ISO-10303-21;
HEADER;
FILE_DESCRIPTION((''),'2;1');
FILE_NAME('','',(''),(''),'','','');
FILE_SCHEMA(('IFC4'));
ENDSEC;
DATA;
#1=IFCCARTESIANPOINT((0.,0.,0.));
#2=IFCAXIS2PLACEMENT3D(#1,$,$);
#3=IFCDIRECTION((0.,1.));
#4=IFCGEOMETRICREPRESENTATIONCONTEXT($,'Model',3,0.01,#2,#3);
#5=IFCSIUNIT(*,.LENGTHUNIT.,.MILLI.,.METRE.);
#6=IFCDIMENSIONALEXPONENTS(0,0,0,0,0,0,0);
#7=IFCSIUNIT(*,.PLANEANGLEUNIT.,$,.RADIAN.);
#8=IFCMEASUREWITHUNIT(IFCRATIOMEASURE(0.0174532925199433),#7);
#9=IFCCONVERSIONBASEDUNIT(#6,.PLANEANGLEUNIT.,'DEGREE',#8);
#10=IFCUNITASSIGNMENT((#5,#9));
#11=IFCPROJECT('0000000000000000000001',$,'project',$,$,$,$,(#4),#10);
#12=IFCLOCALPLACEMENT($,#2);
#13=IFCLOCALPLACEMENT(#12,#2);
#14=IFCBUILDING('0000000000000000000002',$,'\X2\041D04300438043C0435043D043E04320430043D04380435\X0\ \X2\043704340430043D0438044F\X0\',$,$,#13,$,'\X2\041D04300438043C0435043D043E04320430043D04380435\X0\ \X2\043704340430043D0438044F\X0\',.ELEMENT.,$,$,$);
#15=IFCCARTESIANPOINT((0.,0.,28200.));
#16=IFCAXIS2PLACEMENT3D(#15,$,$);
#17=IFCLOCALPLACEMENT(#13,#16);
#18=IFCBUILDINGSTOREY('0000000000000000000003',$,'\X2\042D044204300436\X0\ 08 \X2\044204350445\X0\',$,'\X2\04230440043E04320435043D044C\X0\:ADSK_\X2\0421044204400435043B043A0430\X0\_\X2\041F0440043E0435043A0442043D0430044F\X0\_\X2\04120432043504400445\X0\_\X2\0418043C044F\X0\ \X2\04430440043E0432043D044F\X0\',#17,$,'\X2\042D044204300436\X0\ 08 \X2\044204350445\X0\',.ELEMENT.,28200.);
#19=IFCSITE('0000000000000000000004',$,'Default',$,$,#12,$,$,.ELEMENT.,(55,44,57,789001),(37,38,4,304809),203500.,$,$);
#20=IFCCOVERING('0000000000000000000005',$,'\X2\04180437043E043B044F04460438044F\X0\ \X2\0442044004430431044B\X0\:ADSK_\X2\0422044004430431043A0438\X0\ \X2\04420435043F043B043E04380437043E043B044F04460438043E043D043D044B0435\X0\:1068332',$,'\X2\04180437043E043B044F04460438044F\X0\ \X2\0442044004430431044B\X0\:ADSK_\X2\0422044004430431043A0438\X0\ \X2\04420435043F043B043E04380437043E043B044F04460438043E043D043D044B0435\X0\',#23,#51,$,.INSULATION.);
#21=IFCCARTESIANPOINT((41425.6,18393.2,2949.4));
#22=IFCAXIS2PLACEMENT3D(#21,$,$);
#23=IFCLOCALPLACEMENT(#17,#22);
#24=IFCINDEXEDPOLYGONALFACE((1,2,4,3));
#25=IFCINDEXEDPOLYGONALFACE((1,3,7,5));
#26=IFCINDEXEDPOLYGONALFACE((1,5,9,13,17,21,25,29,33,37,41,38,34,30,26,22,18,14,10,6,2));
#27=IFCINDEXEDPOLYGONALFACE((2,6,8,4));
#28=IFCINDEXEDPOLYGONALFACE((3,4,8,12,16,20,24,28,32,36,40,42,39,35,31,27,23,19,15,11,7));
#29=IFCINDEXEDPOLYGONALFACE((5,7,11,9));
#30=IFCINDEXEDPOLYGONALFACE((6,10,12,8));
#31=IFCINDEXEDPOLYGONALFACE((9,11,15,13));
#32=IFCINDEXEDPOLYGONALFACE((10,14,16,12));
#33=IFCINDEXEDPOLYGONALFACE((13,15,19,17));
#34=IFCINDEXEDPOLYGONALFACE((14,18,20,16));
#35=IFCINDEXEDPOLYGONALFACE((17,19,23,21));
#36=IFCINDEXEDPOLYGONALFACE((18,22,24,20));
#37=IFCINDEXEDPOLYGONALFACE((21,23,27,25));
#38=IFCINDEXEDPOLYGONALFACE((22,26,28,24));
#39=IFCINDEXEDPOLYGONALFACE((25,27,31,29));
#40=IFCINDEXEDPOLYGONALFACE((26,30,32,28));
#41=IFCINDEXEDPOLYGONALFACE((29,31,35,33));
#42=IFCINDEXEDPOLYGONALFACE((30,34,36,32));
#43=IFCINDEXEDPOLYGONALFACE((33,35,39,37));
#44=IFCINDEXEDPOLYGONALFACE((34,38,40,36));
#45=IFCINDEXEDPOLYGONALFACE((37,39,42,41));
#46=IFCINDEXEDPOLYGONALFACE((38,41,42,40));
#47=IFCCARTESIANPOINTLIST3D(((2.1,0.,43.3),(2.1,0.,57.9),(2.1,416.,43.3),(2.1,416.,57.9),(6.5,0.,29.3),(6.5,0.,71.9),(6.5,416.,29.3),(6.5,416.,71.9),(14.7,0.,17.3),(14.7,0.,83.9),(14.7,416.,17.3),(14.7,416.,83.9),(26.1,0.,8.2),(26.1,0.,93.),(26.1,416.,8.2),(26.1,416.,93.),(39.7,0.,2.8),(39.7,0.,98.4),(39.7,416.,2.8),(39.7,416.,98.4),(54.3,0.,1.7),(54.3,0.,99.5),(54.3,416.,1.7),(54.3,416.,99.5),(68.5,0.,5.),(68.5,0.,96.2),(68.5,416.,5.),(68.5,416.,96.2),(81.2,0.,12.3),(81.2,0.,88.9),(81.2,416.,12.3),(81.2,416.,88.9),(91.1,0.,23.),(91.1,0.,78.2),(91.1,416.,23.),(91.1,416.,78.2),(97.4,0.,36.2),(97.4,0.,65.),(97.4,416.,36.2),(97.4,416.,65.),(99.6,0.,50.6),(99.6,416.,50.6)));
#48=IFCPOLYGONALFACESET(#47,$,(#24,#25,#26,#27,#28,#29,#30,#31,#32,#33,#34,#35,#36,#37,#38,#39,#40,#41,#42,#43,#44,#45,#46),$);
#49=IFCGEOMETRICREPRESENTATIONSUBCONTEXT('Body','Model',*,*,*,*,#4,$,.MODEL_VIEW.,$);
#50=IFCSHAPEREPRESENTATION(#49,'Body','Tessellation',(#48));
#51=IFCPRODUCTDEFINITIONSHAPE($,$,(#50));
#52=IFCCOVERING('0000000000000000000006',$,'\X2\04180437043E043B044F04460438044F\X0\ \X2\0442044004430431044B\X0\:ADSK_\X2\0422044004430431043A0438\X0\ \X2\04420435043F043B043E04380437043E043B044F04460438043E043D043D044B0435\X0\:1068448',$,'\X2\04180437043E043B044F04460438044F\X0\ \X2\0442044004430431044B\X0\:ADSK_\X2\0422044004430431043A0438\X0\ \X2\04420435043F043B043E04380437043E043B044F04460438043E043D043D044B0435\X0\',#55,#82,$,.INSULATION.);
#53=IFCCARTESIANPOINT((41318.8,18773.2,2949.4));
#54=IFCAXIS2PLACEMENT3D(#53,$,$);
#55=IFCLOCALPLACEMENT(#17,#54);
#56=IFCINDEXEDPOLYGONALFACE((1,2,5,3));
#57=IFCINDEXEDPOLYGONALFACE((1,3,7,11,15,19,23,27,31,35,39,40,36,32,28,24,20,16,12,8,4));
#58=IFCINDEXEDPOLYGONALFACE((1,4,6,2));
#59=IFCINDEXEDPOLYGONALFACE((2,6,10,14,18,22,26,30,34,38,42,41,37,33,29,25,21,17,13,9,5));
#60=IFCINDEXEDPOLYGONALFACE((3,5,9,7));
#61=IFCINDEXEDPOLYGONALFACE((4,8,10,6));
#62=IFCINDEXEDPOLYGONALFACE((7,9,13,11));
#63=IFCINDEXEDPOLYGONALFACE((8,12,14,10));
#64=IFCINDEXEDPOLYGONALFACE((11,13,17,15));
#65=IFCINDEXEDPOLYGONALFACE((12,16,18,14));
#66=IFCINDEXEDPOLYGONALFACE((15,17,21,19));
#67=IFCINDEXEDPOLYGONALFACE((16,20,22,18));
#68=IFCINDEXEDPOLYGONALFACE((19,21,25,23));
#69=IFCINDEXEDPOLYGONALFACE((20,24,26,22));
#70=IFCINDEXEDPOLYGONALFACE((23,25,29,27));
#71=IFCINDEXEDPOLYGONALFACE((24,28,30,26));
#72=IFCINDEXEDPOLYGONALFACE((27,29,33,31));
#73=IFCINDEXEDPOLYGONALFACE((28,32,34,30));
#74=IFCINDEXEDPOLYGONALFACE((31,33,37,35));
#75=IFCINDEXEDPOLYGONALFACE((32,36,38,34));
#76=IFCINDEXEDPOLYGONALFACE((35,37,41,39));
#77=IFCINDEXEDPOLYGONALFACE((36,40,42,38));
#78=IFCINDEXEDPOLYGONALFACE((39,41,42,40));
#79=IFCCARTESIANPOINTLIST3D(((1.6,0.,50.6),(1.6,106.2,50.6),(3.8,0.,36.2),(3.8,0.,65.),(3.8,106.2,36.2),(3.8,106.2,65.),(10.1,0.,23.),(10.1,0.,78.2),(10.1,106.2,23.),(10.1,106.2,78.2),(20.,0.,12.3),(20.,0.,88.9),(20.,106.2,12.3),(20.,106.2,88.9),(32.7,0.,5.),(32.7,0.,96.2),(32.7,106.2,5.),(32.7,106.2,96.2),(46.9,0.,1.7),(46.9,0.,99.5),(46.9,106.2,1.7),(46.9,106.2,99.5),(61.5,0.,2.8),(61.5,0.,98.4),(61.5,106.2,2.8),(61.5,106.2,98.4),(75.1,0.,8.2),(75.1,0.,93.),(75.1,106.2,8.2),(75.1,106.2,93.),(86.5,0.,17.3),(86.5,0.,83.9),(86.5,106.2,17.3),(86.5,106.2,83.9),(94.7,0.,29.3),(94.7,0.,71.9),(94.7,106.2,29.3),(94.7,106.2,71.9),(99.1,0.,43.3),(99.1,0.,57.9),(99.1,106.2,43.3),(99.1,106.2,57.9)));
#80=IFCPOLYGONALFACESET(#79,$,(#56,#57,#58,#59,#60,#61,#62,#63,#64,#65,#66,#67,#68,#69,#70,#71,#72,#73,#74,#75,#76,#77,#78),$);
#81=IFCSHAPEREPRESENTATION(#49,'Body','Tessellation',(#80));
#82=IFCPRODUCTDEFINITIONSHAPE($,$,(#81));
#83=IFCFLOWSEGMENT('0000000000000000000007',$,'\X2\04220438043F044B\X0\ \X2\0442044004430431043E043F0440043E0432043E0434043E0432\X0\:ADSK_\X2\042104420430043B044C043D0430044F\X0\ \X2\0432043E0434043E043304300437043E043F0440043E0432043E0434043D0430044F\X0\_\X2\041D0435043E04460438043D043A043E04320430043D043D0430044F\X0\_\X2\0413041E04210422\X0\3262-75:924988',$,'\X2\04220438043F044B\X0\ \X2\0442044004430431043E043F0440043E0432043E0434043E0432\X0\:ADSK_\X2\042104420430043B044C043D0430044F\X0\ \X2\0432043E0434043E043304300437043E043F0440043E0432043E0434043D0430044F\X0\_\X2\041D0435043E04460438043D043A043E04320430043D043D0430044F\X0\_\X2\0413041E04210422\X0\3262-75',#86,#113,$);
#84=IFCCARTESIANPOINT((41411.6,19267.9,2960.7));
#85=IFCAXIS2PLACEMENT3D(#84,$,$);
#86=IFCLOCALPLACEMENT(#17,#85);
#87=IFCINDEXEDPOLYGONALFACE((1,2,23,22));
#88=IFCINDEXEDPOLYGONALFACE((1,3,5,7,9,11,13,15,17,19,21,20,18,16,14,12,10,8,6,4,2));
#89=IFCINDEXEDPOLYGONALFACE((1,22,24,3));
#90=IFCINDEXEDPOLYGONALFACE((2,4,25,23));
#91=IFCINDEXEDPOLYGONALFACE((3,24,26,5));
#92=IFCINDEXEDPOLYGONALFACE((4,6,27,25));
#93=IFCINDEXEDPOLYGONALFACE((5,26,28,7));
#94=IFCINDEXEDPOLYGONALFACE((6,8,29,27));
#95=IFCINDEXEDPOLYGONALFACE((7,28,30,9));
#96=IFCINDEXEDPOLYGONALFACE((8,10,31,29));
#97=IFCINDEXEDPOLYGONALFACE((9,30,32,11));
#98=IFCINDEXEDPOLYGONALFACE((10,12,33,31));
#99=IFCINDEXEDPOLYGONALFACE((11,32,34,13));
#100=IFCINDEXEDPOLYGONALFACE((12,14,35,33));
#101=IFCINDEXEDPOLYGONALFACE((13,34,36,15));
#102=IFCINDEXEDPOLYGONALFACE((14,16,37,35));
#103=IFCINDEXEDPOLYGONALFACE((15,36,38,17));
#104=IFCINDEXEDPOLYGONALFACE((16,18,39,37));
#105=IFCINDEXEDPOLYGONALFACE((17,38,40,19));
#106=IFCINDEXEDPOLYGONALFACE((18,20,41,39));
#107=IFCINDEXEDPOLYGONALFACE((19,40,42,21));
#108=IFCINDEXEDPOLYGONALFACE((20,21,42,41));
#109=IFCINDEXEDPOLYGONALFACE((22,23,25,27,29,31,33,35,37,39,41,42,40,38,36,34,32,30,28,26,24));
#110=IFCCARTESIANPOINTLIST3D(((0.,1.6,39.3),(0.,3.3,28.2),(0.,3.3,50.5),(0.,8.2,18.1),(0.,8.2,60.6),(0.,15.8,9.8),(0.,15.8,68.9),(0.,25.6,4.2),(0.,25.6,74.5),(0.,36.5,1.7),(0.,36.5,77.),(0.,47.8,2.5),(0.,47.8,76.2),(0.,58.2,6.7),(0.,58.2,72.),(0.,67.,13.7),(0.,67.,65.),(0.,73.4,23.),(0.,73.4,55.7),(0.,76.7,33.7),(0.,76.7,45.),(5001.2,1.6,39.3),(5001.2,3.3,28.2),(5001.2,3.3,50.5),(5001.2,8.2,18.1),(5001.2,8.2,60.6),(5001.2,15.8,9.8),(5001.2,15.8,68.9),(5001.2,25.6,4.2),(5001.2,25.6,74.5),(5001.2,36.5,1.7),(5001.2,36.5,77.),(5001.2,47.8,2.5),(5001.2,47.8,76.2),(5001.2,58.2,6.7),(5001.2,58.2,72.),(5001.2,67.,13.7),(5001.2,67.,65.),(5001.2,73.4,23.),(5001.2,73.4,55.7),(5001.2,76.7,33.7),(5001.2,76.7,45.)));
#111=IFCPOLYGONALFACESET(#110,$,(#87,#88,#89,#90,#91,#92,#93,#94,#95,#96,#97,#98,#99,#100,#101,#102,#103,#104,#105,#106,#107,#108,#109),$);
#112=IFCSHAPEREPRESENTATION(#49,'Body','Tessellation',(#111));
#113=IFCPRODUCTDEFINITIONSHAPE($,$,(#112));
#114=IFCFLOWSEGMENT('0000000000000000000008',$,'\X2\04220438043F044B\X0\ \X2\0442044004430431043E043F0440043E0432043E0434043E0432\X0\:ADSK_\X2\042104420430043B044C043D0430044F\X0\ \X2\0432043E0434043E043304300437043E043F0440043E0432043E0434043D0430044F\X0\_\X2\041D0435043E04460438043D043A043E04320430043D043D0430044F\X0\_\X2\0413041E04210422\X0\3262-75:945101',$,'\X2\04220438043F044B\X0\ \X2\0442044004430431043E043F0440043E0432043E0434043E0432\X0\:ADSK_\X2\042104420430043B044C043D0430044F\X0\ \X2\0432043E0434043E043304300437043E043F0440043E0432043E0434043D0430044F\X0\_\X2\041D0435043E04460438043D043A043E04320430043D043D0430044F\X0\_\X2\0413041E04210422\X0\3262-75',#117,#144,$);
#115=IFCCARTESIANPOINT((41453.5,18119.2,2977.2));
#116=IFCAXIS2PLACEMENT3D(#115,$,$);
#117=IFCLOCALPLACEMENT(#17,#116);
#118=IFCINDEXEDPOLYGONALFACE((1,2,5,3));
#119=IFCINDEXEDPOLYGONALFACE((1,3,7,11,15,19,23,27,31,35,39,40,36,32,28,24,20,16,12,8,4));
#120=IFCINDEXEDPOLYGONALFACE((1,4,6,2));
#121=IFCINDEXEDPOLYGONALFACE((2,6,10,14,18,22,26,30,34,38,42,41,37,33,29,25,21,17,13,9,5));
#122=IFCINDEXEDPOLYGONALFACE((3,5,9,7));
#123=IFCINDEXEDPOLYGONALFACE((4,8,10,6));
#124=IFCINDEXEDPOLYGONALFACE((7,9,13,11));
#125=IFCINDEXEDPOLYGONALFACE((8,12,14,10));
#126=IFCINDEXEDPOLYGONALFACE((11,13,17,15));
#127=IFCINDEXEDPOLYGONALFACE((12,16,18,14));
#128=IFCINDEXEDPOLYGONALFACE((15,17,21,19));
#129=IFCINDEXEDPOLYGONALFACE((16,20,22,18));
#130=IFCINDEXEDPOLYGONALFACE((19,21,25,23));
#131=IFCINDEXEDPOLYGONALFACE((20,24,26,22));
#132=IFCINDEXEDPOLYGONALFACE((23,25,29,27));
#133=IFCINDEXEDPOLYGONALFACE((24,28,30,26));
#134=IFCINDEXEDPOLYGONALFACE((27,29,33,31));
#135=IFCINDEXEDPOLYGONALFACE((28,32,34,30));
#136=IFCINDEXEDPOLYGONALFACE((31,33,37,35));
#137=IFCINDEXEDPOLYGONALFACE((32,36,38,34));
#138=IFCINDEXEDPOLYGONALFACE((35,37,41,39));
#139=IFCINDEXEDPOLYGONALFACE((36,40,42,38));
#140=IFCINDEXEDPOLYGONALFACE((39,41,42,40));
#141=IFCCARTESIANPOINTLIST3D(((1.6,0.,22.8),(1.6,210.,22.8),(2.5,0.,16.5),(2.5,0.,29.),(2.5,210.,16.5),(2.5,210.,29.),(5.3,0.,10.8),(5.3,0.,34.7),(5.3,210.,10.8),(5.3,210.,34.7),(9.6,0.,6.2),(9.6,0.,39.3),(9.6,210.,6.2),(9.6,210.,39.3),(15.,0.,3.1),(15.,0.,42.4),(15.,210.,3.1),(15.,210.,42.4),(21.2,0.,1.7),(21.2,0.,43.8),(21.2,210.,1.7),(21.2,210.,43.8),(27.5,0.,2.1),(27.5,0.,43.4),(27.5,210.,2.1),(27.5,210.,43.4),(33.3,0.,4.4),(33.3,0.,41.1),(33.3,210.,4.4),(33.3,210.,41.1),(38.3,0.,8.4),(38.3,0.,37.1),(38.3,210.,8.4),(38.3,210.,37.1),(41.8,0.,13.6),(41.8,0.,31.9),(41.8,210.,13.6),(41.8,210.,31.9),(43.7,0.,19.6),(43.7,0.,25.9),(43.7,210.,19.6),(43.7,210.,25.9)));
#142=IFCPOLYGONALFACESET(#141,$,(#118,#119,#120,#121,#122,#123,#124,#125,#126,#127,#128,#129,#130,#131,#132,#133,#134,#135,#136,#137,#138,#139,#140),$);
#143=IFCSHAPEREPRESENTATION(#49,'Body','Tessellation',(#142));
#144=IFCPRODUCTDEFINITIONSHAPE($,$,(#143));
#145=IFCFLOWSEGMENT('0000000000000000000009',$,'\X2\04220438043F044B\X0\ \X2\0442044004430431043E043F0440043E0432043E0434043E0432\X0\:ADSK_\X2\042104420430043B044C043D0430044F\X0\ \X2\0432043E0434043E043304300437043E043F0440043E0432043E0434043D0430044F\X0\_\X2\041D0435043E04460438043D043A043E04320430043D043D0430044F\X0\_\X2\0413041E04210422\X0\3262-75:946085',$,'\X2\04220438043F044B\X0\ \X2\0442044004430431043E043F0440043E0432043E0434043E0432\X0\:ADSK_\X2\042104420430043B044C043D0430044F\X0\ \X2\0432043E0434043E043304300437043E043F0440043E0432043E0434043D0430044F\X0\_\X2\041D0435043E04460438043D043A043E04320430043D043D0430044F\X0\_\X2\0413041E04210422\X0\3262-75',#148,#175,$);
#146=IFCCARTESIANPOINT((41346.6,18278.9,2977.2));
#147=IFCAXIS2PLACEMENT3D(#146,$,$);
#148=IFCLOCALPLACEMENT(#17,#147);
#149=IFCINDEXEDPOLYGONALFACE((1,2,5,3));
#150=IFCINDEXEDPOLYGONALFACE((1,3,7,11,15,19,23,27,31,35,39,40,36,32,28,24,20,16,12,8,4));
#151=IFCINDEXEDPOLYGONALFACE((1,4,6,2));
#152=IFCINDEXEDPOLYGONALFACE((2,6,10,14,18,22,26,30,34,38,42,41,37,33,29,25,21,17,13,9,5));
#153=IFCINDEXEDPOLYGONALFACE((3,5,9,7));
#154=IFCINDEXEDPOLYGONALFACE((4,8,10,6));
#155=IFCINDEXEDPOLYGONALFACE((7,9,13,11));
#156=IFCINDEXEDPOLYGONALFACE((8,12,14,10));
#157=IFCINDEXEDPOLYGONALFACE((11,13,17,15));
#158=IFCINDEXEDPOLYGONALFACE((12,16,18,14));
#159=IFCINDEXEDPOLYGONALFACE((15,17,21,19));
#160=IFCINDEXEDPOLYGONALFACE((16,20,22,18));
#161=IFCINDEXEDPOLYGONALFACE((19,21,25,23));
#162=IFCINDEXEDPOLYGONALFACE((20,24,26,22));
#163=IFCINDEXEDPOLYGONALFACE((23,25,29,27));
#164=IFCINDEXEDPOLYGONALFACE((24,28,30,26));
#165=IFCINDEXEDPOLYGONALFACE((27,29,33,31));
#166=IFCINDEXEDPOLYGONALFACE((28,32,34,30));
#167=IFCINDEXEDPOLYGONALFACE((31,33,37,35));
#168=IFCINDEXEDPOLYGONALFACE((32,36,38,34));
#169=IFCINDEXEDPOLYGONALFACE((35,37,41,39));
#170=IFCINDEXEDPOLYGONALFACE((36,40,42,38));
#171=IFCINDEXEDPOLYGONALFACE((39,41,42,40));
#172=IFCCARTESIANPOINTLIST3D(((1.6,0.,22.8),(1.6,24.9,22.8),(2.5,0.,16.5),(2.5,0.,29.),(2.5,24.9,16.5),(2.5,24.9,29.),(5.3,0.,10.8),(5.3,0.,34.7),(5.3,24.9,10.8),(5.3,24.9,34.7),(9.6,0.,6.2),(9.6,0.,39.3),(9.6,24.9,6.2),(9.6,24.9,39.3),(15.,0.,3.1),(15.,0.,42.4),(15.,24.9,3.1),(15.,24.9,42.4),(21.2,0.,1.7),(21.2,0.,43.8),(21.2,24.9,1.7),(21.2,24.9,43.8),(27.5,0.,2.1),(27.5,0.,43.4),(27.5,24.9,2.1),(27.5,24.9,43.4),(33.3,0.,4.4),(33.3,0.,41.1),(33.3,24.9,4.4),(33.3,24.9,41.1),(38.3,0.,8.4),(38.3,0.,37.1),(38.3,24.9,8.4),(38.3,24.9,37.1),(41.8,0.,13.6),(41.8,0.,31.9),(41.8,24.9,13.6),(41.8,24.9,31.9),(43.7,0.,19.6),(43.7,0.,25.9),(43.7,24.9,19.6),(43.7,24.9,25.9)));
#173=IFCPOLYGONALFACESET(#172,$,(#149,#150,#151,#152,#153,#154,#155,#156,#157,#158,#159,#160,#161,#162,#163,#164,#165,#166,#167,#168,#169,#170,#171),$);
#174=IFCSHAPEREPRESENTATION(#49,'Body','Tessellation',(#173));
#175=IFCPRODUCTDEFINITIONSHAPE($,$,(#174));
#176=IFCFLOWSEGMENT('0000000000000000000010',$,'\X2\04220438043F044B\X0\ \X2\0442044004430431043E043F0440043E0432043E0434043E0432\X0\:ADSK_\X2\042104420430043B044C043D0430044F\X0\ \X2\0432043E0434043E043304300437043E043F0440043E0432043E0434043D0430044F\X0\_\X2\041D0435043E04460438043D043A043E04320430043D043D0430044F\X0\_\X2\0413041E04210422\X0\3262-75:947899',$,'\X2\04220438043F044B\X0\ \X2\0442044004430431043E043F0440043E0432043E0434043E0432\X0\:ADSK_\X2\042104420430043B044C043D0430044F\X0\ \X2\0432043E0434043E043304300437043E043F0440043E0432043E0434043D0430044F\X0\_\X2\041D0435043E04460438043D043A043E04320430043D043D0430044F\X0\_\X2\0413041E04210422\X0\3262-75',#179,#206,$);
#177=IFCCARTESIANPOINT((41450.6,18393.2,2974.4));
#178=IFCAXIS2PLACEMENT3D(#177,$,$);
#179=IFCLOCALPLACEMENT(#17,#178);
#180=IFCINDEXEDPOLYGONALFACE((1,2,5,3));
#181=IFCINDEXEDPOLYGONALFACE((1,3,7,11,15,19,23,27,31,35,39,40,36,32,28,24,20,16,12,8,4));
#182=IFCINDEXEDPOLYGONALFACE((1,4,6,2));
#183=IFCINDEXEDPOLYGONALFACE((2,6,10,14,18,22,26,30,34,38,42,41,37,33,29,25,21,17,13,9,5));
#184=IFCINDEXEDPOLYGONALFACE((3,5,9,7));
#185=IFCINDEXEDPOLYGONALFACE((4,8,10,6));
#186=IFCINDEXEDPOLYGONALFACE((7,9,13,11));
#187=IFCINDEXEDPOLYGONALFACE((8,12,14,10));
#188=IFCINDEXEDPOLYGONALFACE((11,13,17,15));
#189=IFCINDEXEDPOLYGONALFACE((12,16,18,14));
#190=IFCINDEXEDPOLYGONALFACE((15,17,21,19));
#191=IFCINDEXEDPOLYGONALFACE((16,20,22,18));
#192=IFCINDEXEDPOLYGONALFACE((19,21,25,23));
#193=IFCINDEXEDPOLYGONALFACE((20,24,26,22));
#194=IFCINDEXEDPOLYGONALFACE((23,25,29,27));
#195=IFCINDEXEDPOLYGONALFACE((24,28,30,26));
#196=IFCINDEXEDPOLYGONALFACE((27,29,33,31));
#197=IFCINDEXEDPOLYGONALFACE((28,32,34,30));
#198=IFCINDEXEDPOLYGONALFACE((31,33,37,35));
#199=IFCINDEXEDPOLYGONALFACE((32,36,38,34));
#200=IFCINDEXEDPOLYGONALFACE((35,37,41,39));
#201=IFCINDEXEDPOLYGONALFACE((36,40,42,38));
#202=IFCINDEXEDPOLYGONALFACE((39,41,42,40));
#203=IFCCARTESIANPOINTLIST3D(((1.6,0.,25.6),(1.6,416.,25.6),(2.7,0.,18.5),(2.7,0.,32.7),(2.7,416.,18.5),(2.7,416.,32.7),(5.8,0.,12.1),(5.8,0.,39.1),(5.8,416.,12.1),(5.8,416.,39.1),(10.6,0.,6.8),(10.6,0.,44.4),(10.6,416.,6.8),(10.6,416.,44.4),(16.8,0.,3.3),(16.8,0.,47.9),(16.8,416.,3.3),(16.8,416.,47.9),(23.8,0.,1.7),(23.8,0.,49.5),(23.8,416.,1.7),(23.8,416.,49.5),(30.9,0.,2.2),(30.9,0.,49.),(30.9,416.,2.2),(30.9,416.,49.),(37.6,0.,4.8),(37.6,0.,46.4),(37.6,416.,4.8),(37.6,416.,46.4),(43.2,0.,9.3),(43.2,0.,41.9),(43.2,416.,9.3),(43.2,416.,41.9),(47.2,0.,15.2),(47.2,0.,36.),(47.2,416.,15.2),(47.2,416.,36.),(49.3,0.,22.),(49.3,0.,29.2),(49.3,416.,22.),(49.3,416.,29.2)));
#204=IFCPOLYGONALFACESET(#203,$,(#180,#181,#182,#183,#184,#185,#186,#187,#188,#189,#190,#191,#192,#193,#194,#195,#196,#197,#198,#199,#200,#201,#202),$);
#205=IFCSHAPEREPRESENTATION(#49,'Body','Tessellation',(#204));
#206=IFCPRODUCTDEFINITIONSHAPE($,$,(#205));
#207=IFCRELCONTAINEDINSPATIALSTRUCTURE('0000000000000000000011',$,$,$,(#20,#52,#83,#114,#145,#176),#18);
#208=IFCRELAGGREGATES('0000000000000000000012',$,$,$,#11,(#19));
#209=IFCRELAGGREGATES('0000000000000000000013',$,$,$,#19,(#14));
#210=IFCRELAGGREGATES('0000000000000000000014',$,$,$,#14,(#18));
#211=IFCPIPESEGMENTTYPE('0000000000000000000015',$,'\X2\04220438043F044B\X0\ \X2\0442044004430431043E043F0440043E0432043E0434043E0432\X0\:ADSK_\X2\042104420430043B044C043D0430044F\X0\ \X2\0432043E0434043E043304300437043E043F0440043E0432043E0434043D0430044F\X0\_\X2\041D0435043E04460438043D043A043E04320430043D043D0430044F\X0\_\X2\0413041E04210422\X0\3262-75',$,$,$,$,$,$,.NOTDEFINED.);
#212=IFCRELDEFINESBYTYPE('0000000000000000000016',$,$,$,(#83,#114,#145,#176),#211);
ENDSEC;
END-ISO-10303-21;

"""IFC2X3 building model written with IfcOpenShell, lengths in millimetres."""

from ifc_helpers import new_model, entity, si_unit, converted_unit, direction, frame, origin, origin_2d_with_axis, place, context, subcontext, project, spatial, circle, extrude, type_object, element, save


model = new_model("IFC2X3")

# Units and contexts
model_context = context("Model", 3, precision=0.01, world=origin(), true_north=direction((0.0, 1.0)))
body_context = subcontext(model_context, "Body", "Model", "MODEL_VIEW")
ifc_project = project(units=[si_unit("LENGTHUNIT", "METRE", prefix="MILLI"), converted_unit("PLANEANGLEUNIT", "DEGREE", entity("IfcRatioMeasure", 0.0174532925199433), si_unit("PLANEANGLEUNIT", "RADIAN"), dimensions=[0, 0, 0, 0, 0, 0, 0])], contexts=[model_context])

# Site, building, storey
site_placement = place(None, origin())
site = spatial("IfcSite", under=ifc_project, at=site_placement, Name="Default", CompositionType="ELEMENT", RefLatitude=(55, 44, 57, 789001), RefLongitude=(37, 38, 4, 304809), RefElevation=203500.0)
building_placement = place(site_placement, origin())
building = spatial("IfcBuilding", under=site, at=building_placement, Name="Наименование здания", LongName="Наименование здания", CompositionType="ELEMENT")
storey_placement = place(building_placement, frame((0.0, 0.0, 28200.0)))
storey = spatial("IfcBuildingStorey", under=building, at=storey_placement, Name="Этаж 08 тех", ObjectType="Уровень:ADSK_Стрелка_Проектная_Вверх_Имя уровня", LongName="Этаж 08 тех", CompositionType="ELEMENT", Elevation=28200.0)

# Coverings
covering_1_placement = place(storey_placement, frame((41425.6, 18393.2, 2949.4)))
element("IfcCovering", 1, at=covering_1_placement, inside=storey, Name="Изоляция трубы:ADSK_Трубки теплоизоляционные:1068332", ObjectType="Изоляция трубы:ADSK_Трубки теплоизоляционные", PredefinedType="INSULATION", context=body_context, shape_type="SweptSolid", body=[
    extrude(circle(Radius=49.0, at=origin_2d_with_axis()), frame((50.6, 0.0, 50.6), z_axis=(0.0, 1.0, 0.0), x_axis=(1.0, 0.0, 0.0)), (0.0, 0.0, 1.0), 416.0),
])
covering_2_placement = place(storey_placement, frame((41318.8, 18773.2, 2949.4)))
element("IfcCovering", 2, at=covering_2_placement, inside=storey, Name="Изоляция трубы:ADSK_Трубки теплоизоляционные:1068448", ObjectType="Изоляция трубы:ADSK_Трубки теплоизоляционные", PredefinedType="INSULATION", context=body_context, shape_type="SweptSolid", body=[
    extrude(circle(Radius=49.0, at=origin_2d_with_axis()), frame((50.6, 0.0, 50.6), z_axis=(0.0, 1.0, 0.0), x_axis=(-1.0, 0.0, 0.0)), (0.0, 0.0, 1.0), 106.2),
])

# Flow segments
pipe_segment_type = type_object("IfcPipeSegmentType", Name="Типы трубопроводов:ADSK_Стальная водогазопроводная_Неоцинкованная_ГОСТ3262-75", PredefinedType="NOTDEFINED")
flow_segment_1_placement = place(storey_placement, frame((41411.6, 19267.9, 2960.7)))
element("IfcFlowSegment", 3, at=flow_segment_1_placement, inside=storey, type_object=pipe_segment_type, Name="Типы трубопроводов:ADSK_Стальная водогазопроводная_Неоцинкованная_ГОСТ3262-75:924988", ObjectType="Типы трубопроводов:ADSK_Стальная водогазопроводная_Неоцинкованная_ГОСТ3262-75", context=body_context, shape_type="SweptSolid", body=[
    extrude(circle(Radius=37.8, at=origin_2d_with_axis()), frame((0.0, 39.4, 39.4), z_axis=(1.0, 0.0, 0.0), x_axis=(0.0, -1.0, 0.0)), (0.0, 0.0, 1.0), 5001.2),
])
flow_segment_2_placement = place(storey_placement, frame((41453.5, 18119.2, 2977.2)))
element("IfcFlowSegment", 4, at=flow_segment_2_placement, inside=storey, type_object=pipe_segment_type, Name="Типы трубопроводов:ADSK_Стальная водогазопроводная_Неоцинкованная_ГОСТ3262-75:945101", ObjectType="Типы трубопроводов:ADSK_Стальная водогазопроводная_Неоцинкованная_ГОСТ3262-75", context=body_context, shape_type="SweptSolid", body=[
    extrude(circle(Radius=21.1, at=origin_2d_with_axis()), frame((22.8, 0.0, 22.8), z_axis=(0.0, 1.0, 0.0), x_axis=(-1.0, 0.0, 0.0)), (0.0, 0.0, 1.0), 210.0),
])
flow_segment_3_placement = place(storey_placement, frame((41346.6, 18278.9, 2977.2)))
element("IfcFlowSegment", 5, at=flow_segment_3_placement, inside=storey, type_object=pipe_segment_type, Name="Типы трубопроводов:ADSK_Стальная водогазопроводная_Неоцинкованная_ГОСТ3262-75:946085", ObjectType="Типы трубопроводов:ADSK_Стальная водогазопроводная_Неоцинкованная_ГОСТ3262-75", context=body_context, shape_type="SweptSolid", body=[
    extrude(circle(Radius=21.1, at=origin_2d_with_axis()), frame((22.8, 0.0, 22.8), z_axis=(0.0, 1.0, 0.0), x_axis=(-1.0, 0.0, 0.0)), (0.0, 0.0, 1.0), 24.9),
])
flow_segment_4_placement = place(storey_placement, frame((41450.6, 18393.2, 2974.4)))
element("IfcFlowSegment", 6, at=flow_segment_4_placement, inside=storey, type_object=pipe_segment_type, Name="Типы трубопроводов:ADSK_Стальная водогазопроводная_Неоцинкованная_ГОСТ3262-75:947899", ObjectType="Типы трубопроводов:ADSK_Стальная водогазопроводная_Неоцинкованная_ГОСТ3262-75", context=body_context, shape_type="SweptSolid", body=[
    extrude(circle(Radius=24.0, at=origin_2d_with_axis()), frame((25.6, 0.0, 25.6), z_axis=(0.0, 1.0, 0.0), x_axis=(-1.0, 0.0, 0.0)), (0.0, 0.0, 1.0), 416.0),
])

save(model, "model.ifc")
